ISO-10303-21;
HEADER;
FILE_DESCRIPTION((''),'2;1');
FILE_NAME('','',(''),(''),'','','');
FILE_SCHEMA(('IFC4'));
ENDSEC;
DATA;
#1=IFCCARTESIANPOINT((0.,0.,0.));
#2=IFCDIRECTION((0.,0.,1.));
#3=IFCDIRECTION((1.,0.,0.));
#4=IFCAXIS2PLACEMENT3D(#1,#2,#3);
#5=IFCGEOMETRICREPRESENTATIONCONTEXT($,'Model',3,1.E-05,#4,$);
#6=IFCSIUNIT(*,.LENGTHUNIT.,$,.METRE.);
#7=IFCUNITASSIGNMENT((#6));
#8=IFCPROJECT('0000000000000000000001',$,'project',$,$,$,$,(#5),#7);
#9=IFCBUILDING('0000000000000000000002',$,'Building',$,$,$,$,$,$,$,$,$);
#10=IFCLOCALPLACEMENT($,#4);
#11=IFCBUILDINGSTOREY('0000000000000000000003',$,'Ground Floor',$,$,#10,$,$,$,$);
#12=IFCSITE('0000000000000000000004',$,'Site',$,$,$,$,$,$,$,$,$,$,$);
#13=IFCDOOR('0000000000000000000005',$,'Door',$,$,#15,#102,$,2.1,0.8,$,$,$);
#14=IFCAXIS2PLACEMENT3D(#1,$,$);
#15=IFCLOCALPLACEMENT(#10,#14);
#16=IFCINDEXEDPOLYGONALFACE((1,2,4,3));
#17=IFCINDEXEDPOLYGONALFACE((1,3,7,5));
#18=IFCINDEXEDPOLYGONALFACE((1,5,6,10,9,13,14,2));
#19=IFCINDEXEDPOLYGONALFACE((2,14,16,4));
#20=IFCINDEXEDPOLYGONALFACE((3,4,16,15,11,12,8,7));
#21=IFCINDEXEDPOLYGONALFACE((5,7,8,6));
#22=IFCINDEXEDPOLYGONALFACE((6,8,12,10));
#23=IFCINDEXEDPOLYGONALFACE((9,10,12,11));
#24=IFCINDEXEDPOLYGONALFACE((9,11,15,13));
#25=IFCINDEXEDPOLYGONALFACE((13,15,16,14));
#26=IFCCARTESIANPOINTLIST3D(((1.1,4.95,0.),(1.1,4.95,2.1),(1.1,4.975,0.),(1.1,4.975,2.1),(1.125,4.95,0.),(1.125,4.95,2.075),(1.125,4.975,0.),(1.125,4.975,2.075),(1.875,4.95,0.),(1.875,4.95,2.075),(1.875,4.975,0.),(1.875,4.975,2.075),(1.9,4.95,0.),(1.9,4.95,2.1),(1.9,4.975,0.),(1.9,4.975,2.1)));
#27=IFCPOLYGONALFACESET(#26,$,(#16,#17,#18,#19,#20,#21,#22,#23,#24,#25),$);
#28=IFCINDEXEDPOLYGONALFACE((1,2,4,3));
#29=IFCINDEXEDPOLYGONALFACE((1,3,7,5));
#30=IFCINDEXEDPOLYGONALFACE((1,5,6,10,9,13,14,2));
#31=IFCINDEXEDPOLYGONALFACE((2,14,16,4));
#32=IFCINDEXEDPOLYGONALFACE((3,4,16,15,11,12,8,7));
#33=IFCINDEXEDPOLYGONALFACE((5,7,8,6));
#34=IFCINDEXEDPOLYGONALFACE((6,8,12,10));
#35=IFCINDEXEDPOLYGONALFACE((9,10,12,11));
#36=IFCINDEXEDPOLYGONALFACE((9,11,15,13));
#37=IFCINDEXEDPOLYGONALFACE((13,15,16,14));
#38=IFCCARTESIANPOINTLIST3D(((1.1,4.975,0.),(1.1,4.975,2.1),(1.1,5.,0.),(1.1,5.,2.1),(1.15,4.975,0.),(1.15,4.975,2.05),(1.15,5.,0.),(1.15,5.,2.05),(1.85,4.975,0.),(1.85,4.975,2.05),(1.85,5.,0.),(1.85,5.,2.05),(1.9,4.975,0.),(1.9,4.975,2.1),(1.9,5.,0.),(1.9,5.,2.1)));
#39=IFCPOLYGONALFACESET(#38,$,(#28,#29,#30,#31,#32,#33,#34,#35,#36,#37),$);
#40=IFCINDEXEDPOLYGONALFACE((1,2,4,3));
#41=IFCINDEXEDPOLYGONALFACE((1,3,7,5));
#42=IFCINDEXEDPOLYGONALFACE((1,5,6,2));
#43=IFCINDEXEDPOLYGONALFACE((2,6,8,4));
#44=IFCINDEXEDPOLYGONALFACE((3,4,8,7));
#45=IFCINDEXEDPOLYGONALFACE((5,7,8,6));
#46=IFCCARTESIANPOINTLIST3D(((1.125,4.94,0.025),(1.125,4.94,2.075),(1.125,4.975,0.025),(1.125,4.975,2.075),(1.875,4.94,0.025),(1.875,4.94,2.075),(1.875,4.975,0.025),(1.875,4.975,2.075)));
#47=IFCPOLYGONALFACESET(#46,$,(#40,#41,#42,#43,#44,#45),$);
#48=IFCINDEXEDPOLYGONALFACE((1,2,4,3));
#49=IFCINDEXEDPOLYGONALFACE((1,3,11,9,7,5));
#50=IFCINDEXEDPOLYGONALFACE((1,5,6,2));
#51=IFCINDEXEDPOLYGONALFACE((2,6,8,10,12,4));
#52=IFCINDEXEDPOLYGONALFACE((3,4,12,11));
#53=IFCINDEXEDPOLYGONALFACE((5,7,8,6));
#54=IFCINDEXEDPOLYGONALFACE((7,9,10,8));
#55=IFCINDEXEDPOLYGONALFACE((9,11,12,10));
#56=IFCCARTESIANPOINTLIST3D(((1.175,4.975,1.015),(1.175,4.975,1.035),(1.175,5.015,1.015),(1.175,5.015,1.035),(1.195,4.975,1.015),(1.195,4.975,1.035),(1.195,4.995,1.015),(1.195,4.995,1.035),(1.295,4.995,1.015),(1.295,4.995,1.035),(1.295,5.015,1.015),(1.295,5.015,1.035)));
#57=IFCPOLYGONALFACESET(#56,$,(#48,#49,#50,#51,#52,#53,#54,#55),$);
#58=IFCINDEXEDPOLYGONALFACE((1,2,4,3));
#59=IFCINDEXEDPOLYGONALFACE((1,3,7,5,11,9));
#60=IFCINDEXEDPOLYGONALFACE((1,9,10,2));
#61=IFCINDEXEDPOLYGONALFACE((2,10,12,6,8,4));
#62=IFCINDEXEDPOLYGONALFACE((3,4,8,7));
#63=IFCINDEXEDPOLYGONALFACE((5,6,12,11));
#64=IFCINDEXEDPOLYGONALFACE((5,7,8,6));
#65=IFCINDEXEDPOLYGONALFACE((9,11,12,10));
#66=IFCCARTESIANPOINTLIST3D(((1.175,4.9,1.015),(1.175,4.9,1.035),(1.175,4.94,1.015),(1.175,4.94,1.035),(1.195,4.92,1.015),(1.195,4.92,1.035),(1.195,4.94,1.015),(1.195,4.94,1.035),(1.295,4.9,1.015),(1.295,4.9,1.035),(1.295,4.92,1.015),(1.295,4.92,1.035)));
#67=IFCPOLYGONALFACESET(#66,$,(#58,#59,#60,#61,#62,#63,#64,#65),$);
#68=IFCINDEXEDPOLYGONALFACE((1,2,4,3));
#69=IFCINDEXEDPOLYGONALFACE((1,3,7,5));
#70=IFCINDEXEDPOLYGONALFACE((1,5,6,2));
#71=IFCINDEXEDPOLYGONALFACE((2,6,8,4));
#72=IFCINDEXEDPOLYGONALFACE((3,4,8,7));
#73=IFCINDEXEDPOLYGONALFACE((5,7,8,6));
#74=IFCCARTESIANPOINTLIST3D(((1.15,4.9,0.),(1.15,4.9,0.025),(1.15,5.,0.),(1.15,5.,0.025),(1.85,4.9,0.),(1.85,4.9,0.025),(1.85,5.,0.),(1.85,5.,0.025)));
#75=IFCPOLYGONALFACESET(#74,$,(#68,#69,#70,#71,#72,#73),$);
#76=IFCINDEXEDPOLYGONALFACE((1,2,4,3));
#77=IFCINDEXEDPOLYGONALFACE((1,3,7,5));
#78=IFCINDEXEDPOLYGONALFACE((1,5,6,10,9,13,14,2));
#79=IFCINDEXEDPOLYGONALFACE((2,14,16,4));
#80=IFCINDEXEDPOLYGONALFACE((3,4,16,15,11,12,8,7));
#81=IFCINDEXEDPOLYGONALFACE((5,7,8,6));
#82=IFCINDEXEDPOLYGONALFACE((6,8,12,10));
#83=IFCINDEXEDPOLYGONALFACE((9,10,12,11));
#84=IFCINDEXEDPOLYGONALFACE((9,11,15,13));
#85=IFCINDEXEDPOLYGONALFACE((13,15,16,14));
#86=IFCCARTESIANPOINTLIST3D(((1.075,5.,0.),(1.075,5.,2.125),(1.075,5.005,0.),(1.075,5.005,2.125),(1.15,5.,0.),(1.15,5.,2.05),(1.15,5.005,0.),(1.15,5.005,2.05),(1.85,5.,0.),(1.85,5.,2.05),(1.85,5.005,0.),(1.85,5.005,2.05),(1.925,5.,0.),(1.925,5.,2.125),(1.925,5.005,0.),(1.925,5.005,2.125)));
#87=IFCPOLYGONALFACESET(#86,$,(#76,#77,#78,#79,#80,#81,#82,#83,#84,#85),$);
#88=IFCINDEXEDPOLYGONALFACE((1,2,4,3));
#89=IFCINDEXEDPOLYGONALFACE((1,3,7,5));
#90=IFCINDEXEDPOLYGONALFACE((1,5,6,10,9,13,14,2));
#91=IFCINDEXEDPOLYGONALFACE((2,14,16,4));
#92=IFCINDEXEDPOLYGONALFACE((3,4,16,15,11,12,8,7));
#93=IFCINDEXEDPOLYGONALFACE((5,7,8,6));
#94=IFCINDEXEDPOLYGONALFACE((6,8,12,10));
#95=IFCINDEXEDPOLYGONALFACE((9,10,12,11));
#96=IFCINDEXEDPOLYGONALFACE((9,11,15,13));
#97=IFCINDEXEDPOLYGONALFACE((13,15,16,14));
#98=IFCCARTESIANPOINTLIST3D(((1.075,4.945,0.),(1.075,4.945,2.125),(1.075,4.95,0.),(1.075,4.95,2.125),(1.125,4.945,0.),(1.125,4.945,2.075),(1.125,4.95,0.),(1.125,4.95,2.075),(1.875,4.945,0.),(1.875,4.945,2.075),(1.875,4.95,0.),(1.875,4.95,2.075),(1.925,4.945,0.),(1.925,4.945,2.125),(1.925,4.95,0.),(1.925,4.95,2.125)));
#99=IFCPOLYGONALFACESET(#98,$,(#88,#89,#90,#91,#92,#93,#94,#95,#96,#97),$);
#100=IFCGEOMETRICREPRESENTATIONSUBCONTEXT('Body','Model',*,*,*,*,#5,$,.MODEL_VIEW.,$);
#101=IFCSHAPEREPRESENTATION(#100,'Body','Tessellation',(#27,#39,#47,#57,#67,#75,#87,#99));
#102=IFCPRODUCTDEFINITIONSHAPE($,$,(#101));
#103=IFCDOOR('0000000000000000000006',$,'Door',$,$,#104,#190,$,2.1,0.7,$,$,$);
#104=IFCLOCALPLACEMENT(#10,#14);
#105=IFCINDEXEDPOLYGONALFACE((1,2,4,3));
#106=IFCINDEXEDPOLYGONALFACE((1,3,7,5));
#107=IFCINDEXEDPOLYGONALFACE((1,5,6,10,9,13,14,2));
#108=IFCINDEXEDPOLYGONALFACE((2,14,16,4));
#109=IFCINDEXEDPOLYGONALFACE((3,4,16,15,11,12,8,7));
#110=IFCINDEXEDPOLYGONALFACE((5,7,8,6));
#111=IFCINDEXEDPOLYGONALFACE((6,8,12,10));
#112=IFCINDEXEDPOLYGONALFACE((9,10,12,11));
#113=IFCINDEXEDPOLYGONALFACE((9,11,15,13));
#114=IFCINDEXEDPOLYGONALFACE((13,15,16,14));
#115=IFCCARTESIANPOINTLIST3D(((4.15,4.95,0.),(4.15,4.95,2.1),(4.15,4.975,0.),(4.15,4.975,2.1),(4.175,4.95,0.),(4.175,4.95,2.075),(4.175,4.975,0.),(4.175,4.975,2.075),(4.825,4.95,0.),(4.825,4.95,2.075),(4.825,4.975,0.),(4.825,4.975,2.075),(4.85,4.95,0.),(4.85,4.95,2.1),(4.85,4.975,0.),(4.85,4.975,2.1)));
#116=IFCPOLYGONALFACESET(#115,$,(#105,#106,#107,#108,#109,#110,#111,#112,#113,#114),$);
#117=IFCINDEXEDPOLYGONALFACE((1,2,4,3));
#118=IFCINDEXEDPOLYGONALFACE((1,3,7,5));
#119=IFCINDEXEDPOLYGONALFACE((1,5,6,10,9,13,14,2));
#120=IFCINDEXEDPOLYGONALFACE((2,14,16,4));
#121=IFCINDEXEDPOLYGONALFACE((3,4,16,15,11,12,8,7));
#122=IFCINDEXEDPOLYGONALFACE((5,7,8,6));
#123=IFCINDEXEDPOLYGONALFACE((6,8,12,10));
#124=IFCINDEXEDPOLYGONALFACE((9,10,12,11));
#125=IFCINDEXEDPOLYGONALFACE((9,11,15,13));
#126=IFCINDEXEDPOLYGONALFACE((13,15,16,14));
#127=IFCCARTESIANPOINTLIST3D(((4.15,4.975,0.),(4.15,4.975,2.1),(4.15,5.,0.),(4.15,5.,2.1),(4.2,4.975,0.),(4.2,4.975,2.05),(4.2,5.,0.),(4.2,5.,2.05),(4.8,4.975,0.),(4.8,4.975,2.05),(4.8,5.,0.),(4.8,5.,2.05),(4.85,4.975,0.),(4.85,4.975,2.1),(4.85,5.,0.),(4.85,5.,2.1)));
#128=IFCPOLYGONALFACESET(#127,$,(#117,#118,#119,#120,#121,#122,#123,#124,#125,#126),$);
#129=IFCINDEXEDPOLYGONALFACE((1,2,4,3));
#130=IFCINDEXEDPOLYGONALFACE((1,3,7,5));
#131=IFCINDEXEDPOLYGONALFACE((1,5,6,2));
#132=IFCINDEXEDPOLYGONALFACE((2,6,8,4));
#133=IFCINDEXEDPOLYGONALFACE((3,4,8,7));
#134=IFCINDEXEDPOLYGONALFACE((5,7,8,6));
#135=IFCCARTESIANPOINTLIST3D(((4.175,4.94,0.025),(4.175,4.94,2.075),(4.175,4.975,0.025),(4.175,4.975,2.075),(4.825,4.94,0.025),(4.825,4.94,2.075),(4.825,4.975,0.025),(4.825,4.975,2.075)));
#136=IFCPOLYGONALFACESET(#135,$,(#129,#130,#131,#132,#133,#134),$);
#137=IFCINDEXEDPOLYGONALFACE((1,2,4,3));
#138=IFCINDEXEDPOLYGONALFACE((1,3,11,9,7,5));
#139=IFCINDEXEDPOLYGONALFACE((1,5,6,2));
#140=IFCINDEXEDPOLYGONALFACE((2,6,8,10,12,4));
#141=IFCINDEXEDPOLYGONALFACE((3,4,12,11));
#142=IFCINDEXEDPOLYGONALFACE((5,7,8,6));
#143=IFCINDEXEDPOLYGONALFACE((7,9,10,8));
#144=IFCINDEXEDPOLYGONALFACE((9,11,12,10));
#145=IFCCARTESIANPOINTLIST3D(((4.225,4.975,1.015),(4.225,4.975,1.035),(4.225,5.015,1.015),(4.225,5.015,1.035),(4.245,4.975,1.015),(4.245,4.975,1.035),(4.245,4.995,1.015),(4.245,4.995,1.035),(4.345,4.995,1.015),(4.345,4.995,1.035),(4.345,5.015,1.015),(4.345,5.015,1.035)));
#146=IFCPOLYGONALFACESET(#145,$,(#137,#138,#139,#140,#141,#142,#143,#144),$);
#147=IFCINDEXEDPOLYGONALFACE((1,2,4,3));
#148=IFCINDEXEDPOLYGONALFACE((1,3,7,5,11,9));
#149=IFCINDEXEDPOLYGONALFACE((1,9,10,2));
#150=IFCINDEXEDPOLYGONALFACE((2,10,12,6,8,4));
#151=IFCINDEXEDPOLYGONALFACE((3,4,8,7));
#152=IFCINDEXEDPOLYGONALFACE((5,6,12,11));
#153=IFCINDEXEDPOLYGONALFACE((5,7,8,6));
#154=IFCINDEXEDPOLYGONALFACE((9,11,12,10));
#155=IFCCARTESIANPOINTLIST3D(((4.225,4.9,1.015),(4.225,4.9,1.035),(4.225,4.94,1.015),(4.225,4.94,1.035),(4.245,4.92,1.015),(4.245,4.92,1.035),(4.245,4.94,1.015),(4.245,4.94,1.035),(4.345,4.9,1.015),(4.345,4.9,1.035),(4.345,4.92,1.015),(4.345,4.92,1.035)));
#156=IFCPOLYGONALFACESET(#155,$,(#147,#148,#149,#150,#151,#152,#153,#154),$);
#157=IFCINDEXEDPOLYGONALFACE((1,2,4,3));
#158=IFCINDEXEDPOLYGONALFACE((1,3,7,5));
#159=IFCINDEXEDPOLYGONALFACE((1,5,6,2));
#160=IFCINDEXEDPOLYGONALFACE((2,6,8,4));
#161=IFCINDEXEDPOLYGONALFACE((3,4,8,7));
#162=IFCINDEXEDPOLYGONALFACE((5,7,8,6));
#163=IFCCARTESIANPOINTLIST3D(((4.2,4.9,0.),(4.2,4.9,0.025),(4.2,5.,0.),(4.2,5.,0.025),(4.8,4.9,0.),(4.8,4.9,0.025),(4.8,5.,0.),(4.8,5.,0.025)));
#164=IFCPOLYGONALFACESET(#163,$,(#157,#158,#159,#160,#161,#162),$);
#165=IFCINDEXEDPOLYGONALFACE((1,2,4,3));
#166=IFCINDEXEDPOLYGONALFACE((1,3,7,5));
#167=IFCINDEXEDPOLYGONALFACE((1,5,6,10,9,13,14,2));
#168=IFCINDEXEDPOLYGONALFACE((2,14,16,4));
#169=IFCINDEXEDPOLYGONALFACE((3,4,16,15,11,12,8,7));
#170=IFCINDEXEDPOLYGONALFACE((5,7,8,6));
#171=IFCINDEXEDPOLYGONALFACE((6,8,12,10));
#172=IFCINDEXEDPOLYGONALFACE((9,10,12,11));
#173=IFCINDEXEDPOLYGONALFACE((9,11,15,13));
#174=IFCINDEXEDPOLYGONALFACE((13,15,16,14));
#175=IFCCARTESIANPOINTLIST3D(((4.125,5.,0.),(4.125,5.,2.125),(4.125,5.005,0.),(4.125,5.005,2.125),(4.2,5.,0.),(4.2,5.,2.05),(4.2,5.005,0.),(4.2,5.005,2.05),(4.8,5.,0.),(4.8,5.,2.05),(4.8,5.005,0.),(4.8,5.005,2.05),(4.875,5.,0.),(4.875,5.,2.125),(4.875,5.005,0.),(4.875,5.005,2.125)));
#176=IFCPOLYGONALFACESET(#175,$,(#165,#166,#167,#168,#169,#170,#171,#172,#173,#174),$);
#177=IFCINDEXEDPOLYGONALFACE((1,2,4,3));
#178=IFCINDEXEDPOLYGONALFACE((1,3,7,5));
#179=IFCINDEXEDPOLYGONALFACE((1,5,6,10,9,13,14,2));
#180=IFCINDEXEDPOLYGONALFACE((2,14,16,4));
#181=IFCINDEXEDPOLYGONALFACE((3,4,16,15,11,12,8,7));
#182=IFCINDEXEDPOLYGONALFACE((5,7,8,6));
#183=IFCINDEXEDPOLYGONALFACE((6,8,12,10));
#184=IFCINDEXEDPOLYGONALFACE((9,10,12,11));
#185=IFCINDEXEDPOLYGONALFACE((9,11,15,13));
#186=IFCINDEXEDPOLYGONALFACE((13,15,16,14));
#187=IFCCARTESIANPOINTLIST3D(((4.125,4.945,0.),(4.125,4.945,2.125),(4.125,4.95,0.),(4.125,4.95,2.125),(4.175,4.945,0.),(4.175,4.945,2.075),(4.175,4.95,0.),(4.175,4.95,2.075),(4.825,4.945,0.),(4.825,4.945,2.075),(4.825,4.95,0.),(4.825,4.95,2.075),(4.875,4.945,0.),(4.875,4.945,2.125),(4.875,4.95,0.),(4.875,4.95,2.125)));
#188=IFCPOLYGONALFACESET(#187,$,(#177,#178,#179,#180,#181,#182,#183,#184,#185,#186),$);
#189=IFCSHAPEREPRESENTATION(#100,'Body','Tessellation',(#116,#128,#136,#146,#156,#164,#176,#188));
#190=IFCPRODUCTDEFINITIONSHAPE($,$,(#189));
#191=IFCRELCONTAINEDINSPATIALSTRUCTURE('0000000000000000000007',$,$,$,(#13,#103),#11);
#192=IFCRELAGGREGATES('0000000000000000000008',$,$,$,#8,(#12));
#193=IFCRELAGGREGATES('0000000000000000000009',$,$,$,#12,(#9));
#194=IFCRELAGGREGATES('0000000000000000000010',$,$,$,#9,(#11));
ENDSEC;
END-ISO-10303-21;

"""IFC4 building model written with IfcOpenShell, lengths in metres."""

from ifc_helpers import new_model, si_unit, frame, origin_with_axes, place, context, subcontext, project, spatial, line, indexed_curve, outline, extrude, element, save


model = new_model("IFC4")

# Units and contexts
model_context = context("Model", 3, precision=1e-05, world=origin_with_axes())
body_context = subcontext(model_context, "Body", "Model", "MODEL_VIEW")
ifc_project = project(units=[si_unit("LENGTHUNIT", "METRE")], contexts=[model_context])

# Site, building, storey
site = spatial("IfcSite", under=ifc_project, Name="Site")
building = spatial("IfcBuilding", under=site, Name="Building")
storey_placement = place(None, origin_with_axes())
storey = spatial("IfcBuildingStorey", under=building, at=storey_placement, Name="Ground Floor")

# Doors
door_1_placement = place(storey_placement, frame((1.9, 5.0, 0.0), z_axis=(0.0, 0.0, 1.0), x_axis=(-1.0, 0.0, 0.0)))
element("IfcDoor", 1, at=door_1_placement, inside=storey, Name="Door", OverallHeight=2.1, OverallWidth=0.8, context=body_context, shape_type="SweptSolid", body=[
    extrude(outline(indexed_curve([(0.0, 0.0), (0.0, 2.1), (0.8, 2.1), (0.8, 0.0), (0.775, 0.0), (0.775, 2.075), (0.025, 2.075), (0.025, 0.0)], segments=[line(1, 2, 3, 4, 5, 6, 7, 8, 1)])), frame((0.0, 0.025, 0.0), z_axis=(0.0, -1.0, 0.0), x_axis=(1.0, 0.0, 0.0)), (0.0, 0.0, -1.0), 0.025),
    extrude(outline(indexed_curve([(0.0, 0.0), (0.0, 2.1), (0.8, 2.1), (0.8, 0.0), (0.75, 0.0), (0.75, 2.05), (0.05, 2.05), (0.05, 0.0)], segments=[line(1, 2, 3, 4, 5, 6, 7, 8, 1)])), frame((0.0, 0.0, 0.0), z_axis=(0.0, -1.0, 0.0), x_axis=(1.0, 0.0, 0.0)), (0.0, 0.0, -1.0), 0.025),
    extrude(outline(indexed_curve([(0.0, 0.0), (0.75, 0.0), (0.75, 0.035), (0.0, 0.035)], segments=[line(1, 2, 3, 4, 1)])), frame((0.025, 0.025, 0.025), z_axis=(0.0, 0.0, 1.0), x_axis=(1.0, 0.0, 0.0)), (0.0, 0.0, 1.0), 2.05),
    extrude(outline(indexed_curve([(0.0, 0.0), (0.0, -0.04), (-0.12, -0.04), (-0.12, -0.02), (-0.02, -0.02), (-0.02, 0.0)], segments=[line(1, 2, 3, 4, 5, 6, 1)])), frame((0.725, 0.025, 1.015), z_axis=(0.0, 0.0, 1.0), x_axis=(1.0, 0.0, 0.0)), (0.0, 0.0, 1.0), 0.02),
    extrude(outline(indexed_curve([(0.0, 0.0), (0.0, 0.04), (-0.12, 0.04), (-0.12, 0.02), (-0.02, 0.02), (-0.02, 0.0)], segments=[line(1, 2, 3, 4, 5, 6, 1)])), frame((0.725, 0.06, 1.015), z_axis=(0.0, 0.0, 1.0), x_axis=(1.0, 0.0, 0.0)), (0.0, 0.0, 1.0), 0.02),
    extrude(outline(indexed_curve([(0.0, 0.0), (0.7, 0.0), (0.7, 0.1), (0.0, 0.1)], segments=[line(1, 2, 3, 4, 1)])), frame((0.05, 0.0, 0.0), z_axis=(0.0, 0.0, 1.0), x_axis=(1.0, 0.0, 0.0)), (0.0, 0.0, 1.0), 0.025),
    extrude(outline(indexed_curve([(0.0, 0.0), (0.0, 2.125), (0.85, 2.125), (0.85, 0.0), (0.775, 0.0), (0.775, 2.05), (0.075, 2.05), (0.075, 0.0)], segments=[line(1, 2, 3, 4, 5, 6, 7, 8, 1)])), frame((-0.025, -0.005, 0.0), z_axis=(0.0, -1.0, 0.0), x_axis=(1.0, 0.0, 0.0)), (0.0, 0.0, -1.0), 0.005),
    extrude(outline(indexed_curve([(0.0, 0.0), (0.0, 2.125), (0.85, 2.125), (0.85, 0.0), (0.8, 0.0), (0.8, 2.075), (0.05, 2.075), (0.05, 0.0)], segments=[line(1, 2, 3, 4, 5, 6, 7, 8, 1)])), frame((-0.025, 0.05, 0.0), z_axis=(0.0, -1.0, 0.0), x_axis=(1.0, 0.0, 0.0)), (0.0, 0.0, -1.0), 0.005),
])
door_2_placement = place(storey_placement, frame((4.85, 5.0, 0.0), z_axis=(0.0, 0.0, 1.0), x_axis=(-1.0, 0.0, 0.0)))
element("IfcDoor", 2, at=door_2_placement, inside=storey, Name="Door", OverallHeight=2.1, OverallWidth=0.7, context=body_context, shape_type="SweptSolid", body=[
    extrude(outline(indexed_curve([(0.0, 0.0), (0.0, 2.1), (0.7, 2.1), (0.7, 0.0), (0.675, 0.0), (0.675, 2.075), (0.025, 2.075), (0.025, 0.0)], segments=[line(1, 2, 3, 4, 5, 6, 7, 8, 1)])), frame((0.0, 0.025, 0.0), z_axis=(0.0, -1.0, 0.0), x_axis=(1.0, 0.0, 0.0)), (0.0, 0.0, -1.0), 0.025),
    extrude(outline(indexed_curve([(0.0, 0.0), (0.0, 2.1), (0.7, 2.1), (0.7, 0.0), (0.65, 0.0), (0.65, 2.05), (0.05, 2.05), (0.05, 0.0)], segments=[line(1, 2, 3, 4, 5, 6, 7, 8, 1)])), frame((0.0, 0.0, 0.0), z_axis=(0.0, -1.0, 0.0), x_axis=(1.0, 0.0, 0.0)), (0.0, 0.0, -1.0), 0.025),
    extrude(outline(indexed_curve([(0.0, 0.0), (0.65, 0.0), (0.65, 0.035), (0.0, 0.035)], segments=[line(1, 2, 3, 4, 1)])), frame((0.025, 0.025, 0.025), z_axis=(0.0, 0.0, 1.0), x_axis=(1.0, 0.0, 0.0)), (0.0, 0.0, 1.0), 2.05),
    extrude(outline(indexed_curve([(0.0, 0.0), (0.0, -0.04), (-0.12, -0.04), (-0.12, -0.02), (-0.02, -0.02), (-0.02, 0.0)], segments=[line(1, 2, 3, 4, 5, 6, 1)])), frame((0.625, 0.025, 1.015), z_axis=(0.0, 0.0, 1.0), x_axis=(1.0, 0.0, 0.0)), (0.0, 0.0, 1.0), 0.02),
    extrude(outline(indexed_curve([(0.0, 0.0), (0.0, 0.04), (-0.12, 0.04), (-0.12, 0.02), (-0.02, 0.02), (-0.02, 0.0)], segments=[line(1, 2, 3, 4, 5, 6, 1)])), frame((0.625, 0.06, 1.015), z_axis=(0.0, 0.0, 1.0), x_axis=(1.0, 0.0, 0.0)), (0.0, 0.0, 1.0), 0.02),
    extrude(outline(indexed_curve([(0.0, 0.0), (0.6, 0.0), (0.6, 0.1), (0.0, 0.1)], segments=[line(1, 2, 3, 4, 1)])), frame((0.05, 0.0, 0.0), z_axis=(0.0, 0.0, 1.0), x_axis=(1.0, 0.0, 0.0)), (0.0, 0.0, 1.0), 0.025),
    extrude(outline(indexed_curve([(0.0, 0.0), (0.0, 2.125), (0.75, 2.125), (0.75, 0.0), (0.675, 0.0), (0.675, 2.05), (0.075, 2.05), (0.075, 0.0)], segments=[line(1, 2, 3, 4, 5, 6, 7, 8, 1)])), frame((-0.025, -0.005, 0.0), z_axis=(0.0, -1.0, 0.0), x_axis=(1.0, 0.0, 0.0)), (0.0, 0.0, -1.0), 0.005),
    extrude(outline(indexed_curve([(0.0, 0.0), (0.0, 2.125), (0.75, 2.125), (0.75, 0.0), (0.7, 0.0), (0.7, 2.075), (0.05, 2.075), (0.05, 0.0)], segments=[line(1, 2, 3, 4, 5, 6, 7, 8, 1)])), frame((-0.025, 0.05, 0.0), z_axis=(0.0, -1.0, 0.0), x_axis=(1.0, 0.0, 0.0)), (0.0, 0.0, -1.0), 0.005),
])

save(model, "model.ifc")
